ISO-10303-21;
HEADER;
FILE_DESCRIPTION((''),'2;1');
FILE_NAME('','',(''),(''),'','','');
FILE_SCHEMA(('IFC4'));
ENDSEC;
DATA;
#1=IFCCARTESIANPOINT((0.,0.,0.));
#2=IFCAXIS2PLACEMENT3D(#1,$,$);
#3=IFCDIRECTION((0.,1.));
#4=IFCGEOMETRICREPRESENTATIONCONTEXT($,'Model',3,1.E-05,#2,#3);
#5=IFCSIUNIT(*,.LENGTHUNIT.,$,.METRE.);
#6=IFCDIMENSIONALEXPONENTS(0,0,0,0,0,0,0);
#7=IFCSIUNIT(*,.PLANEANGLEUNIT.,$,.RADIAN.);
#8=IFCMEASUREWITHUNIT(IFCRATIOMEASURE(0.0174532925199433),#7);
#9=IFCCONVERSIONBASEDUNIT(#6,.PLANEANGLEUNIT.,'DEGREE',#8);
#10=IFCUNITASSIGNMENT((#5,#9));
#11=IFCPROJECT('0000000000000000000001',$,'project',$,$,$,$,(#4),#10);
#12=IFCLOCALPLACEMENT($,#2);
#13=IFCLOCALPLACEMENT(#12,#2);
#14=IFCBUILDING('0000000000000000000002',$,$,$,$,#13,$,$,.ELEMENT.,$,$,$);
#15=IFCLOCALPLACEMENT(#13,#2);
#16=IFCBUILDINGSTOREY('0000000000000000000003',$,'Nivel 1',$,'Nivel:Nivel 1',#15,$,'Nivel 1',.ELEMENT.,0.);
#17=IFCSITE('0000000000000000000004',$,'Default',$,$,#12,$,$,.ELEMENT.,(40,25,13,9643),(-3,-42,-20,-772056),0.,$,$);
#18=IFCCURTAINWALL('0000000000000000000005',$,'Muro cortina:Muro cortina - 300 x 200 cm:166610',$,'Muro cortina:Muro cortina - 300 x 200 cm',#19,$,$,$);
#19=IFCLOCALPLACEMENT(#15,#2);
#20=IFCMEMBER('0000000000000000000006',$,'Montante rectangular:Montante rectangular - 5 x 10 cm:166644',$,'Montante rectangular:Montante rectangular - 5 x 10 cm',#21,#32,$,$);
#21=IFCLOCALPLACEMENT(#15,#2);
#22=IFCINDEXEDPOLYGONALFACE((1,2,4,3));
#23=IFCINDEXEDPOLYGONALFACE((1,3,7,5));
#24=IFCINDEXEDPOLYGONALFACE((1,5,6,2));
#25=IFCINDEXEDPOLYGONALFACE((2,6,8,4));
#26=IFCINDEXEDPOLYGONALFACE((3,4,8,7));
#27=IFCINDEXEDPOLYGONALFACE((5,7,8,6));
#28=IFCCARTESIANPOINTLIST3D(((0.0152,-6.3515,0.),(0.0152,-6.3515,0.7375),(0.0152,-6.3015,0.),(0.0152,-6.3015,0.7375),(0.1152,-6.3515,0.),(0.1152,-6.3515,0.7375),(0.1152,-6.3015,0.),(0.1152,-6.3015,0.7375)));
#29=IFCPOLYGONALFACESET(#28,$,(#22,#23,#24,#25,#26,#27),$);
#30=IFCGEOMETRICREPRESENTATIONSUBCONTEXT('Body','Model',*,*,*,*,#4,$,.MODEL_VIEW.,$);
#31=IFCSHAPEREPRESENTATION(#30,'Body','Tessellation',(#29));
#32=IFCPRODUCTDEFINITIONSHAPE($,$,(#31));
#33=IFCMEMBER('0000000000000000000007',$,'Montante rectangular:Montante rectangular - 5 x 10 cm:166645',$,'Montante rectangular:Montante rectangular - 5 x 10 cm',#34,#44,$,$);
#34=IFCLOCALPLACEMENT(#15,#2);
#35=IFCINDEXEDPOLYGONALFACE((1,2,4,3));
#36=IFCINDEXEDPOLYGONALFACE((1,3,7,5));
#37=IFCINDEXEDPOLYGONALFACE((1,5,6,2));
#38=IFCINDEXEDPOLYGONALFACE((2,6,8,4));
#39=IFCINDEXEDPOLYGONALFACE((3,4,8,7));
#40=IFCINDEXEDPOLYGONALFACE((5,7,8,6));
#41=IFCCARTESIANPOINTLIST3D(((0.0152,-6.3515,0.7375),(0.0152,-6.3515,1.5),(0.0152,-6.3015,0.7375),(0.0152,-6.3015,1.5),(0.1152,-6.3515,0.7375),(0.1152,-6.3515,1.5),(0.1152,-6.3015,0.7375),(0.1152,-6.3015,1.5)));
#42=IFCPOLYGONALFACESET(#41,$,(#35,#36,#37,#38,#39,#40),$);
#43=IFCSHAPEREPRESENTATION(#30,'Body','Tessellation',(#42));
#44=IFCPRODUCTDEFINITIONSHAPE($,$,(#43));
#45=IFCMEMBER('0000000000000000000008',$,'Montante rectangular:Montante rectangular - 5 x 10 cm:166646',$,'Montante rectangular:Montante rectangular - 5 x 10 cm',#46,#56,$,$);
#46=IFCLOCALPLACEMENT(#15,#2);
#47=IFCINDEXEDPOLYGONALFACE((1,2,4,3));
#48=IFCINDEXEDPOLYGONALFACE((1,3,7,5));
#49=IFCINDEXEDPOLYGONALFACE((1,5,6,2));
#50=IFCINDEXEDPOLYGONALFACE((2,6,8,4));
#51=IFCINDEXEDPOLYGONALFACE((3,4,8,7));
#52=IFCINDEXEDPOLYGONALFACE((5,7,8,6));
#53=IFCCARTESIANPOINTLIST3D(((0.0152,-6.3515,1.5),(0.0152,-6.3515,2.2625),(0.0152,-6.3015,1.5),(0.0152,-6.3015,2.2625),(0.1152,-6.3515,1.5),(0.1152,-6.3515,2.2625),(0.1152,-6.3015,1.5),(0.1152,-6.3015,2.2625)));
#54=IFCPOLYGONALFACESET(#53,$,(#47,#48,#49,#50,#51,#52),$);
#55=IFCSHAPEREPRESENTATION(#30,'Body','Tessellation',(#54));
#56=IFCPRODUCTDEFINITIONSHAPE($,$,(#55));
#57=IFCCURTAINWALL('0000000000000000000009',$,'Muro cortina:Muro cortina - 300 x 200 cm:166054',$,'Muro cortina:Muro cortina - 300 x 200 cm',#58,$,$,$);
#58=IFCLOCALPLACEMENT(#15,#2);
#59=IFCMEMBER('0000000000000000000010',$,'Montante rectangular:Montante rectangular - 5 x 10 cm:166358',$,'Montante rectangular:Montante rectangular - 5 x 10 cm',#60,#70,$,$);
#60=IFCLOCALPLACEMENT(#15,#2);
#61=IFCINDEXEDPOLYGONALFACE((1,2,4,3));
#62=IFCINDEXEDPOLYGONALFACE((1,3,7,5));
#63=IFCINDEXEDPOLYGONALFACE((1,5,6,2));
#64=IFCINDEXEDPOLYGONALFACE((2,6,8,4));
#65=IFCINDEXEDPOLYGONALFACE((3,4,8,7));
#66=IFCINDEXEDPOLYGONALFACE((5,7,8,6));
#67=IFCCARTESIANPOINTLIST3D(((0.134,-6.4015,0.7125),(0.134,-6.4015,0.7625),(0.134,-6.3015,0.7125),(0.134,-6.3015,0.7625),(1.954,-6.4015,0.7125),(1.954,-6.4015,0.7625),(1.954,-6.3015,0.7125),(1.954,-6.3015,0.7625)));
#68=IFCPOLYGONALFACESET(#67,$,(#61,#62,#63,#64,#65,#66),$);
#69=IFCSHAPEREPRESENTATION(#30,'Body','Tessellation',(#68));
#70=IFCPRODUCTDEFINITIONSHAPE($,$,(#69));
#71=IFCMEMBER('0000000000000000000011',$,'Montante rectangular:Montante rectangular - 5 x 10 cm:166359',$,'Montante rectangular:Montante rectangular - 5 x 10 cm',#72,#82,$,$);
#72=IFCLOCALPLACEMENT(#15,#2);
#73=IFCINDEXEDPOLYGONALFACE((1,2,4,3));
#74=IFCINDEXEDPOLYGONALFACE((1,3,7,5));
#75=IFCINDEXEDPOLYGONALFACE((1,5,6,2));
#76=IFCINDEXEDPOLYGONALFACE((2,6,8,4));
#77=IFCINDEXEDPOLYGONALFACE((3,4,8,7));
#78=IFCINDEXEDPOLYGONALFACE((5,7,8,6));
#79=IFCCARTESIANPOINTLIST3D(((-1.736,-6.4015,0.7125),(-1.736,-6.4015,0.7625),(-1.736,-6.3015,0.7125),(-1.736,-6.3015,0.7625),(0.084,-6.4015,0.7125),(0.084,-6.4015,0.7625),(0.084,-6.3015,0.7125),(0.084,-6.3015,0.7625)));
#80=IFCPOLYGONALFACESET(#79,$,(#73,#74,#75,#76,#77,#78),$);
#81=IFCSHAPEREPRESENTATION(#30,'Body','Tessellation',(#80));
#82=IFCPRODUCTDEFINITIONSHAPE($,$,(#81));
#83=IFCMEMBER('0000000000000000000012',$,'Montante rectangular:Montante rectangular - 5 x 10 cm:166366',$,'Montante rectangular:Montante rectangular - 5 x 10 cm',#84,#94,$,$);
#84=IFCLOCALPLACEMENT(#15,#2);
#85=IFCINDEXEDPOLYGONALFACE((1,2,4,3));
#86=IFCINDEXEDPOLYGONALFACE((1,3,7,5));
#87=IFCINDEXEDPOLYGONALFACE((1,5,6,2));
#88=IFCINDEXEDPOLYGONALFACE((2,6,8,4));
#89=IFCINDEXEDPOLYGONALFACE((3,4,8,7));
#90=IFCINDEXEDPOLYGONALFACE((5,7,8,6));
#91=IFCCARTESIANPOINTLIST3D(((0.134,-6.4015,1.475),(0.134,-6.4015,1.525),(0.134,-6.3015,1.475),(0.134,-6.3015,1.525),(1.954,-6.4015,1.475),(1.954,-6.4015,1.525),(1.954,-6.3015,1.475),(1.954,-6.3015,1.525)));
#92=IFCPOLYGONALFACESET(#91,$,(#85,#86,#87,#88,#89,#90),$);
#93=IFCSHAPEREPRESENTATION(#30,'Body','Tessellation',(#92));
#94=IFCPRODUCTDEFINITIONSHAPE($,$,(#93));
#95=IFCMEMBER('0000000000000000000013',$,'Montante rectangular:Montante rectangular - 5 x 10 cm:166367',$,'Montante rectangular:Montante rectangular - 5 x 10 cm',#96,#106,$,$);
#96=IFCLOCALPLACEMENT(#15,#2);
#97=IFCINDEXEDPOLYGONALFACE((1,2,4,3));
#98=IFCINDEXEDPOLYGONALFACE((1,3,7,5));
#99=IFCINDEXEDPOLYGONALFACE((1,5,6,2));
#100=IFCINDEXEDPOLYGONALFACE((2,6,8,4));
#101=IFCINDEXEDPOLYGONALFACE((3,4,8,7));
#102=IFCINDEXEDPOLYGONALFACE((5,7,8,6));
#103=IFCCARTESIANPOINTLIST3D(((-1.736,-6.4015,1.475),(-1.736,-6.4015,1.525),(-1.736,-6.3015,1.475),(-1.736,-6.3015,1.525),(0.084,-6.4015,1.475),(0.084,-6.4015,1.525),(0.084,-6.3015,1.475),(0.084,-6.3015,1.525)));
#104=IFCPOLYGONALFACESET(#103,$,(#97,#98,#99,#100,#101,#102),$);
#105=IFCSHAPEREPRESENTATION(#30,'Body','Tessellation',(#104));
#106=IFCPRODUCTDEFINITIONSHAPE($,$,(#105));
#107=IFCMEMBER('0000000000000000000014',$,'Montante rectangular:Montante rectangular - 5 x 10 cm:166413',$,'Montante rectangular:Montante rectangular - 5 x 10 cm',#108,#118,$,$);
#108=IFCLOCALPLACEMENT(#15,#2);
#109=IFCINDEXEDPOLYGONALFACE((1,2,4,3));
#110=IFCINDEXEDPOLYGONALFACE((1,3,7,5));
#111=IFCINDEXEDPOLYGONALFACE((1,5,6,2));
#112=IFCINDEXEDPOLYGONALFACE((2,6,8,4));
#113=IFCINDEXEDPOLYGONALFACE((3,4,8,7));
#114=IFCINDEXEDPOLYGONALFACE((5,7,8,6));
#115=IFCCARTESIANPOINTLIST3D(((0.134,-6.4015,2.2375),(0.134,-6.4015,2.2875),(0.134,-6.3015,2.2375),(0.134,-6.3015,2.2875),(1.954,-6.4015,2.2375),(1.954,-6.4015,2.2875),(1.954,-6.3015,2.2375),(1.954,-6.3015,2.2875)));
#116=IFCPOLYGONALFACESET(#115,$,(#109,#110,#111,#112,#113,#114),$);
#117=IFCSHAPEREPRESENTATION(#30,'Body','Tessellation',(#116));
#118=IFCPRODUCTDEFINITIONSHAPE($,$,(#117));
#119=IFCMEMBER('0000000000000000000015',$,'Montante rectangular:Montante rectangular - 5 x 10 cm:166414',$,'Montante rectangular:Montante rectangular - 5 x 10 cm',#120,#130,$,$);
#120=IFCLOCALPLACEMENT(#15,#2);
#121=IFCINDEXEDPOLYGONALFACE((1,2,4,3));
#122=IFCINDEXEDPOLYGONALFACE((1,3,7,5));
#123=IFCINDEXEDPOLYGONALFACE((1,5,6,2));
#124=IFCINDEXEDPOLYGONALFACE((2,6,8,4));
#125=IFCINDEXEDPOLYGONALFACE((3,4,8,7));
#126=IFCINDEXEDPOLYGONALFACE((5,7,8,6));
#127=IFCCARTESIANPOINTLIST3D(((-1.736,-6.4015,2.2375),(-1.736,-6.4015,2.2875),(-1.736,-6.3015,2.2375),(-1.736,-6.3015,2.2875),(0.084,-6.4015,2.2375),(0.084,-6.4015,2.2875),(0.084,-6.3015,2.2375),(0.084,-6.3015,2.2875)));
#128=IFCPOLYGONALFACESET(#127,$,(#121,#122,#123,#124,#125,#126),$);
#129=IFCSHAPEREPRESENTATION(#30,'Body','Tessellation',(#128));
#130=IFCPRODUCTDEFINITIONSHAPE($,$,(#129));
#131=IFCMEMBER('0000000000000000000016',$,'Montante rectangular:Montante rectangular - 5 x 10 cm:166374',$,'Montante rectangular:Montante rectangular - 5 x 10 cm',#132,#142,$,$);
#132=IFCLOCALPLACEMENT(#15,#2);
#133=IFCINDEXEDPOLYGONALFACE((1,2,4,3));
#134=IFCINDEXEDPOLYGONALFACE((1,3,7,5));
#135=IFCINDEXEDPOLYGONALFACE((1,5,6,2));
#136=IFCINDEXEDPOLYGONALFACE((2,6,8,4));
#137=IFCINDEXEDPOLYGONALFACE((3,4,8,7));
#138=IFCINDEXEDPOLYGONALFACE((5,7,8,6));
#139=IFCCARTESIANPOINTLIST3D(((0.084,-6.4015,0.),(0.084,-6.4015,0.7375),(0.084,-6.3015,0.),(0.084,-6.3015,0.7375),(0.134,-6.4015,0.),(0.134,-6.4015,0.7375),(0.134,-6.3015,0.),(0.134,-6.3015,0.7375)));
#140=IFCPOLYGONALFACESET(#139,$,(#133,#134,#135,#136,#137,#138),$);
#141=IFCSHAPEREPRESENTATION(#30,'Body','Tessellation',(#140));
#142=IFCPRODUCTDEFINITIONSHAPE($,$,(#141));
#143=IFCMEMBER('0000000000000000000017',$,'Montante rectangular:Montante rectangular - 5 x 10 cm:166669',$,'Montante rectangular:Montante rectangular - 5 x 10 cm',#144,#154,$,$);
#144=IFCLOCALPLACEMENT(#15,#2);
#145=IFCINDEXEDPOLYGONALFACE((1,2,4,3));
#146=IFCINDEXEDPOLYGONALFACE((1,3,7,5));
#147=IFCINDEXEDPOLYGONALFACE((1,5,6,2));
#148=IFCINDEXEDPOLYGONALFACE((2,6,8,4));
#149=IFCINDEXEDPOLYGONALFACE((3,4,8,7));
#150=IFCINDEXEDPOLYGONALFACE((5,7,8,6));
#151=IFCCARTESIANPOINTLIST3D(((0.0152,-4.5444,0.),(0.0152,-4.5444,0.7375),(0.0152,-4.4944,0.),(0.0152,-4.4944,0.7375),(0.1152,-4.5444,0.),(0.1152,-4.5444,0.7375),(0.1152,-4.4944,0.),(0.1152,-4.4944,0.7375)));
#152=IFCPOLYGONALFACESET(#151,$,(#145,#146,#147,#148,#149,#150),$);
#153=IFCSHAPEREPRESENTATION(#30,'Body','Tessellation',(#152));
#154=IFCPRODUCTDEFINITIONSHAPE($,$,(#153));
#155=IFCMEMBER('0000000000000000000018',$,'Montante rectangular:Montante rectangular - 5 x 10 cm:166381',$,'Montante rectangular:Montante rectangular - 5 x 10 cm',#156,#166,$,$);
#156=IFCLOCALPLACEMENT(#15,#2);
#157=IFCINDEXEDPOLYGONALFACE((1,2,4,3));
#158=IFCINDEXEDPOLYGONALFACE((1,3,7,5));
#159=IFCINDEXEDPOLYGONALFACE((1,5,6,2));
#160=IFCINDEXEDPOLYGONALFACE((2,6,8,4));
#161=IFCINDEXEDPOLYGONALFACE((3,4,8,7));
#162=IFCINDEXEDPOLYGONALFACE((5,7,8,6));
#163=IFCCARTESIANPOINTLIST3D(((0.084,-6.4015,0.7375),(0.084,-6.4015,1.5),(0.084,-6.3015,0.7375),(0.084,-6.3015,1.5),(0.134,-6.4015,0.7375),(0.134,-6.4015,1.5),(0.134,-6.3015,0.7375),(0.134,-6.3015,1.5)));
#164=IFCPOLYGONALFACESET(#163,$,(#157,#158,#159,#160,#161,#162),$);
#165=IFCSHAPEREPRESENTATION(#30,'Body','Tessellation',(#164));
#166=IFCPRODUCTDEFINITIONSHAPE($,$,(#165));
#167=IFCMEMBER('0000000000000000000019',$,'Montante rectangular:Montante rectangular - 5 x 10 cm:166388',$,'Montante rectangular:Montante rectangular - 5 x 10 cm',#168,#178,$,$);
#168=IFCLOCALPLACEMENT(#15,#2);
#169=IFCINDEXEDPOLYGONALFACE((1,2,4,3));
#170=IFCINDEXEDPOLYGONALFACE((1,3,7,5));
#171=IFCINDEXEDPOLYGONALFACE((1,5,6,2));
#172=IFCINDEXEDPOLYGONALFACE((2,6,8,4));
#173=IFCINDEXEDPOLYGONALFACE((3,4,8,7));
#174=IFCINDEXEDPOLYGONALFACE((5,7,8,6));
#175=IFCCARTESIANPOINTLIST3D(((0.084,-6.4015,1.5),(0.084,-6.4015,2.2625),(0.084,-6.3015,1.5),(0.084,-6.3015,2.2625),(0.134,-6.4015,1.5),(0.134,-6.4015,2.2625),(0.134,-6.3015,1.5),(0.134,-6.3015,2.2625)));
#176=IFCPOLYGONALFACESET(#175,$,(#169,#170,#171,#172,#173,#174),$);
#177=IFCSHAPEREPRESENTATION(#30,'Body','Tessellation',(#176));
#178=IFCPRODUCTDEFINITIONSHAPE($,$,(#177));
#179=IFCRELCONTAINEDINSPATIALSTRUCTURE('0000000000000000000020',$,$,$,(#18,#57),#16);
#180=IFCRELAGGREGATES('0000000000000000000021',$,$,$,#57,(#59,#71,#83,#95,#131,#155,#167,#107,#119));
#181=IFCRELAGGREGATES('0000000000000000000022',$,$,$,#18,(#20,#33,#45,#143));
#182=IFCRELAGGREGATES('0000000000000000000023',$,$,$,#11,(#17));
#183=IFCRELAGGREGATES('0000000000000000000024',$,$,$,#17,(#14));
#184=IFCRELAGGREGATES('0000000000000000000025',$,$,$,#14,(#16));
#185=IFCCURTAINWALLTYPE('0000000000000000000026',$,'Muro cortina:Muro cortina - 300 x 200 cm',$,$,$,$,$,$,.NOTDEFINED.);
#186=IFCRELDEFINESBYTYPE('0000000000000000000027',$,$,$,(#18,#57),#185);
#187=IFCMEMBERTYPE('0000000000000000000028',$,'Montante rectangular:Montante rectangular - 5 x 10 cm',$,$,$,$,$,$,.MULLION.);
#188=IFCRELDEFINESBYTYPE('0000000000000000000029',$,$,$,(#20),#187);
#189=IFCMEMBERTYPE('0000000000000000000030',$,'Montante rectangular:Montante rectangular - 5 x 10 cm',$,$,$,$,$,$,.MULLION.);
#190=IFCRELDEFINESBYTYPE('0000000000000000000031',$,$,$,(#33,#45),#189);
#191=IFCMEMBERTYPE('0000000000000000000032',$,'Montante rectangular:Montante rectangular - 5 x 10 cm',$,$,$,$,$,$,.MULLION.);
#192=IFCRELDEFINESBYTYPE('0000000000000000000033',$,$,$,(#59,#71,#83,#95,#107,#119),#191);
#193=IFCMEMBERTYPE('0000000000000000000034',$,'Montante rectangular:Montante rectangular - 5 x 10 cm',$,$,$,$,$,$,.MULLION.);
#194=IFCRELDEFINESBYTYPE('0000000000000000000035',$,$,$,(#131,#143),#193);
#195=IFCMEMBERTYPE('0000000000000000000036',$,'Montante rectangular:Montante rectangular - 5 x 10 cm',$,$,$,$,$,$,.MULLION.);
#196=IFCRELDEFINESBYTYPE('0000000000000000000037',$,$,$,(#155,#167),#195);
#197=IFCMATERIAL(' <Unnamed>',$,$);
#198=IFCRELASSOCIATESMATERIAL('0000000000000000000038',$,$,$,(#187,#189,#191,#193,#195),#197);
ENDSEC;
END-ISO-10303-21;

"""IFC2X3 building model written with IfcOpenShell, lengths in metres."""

from ifc_helpers import new_model, entity, si_unit, converted_unit, direction, frame, origin, origin_2d_with_axis, place, context, subcontext, project, spatial, rectangle, extrude, source, transform, mapped, material, type_object, type_shapes, element, aggregate, save


model = new_model("IFC2X3")

# Units and contexts
model_context = context("Model", 3, precision=1e-05, world=origin(), true_north=direction((0.0, 1.0)))
body_context = subcontext(model_context, "Body", "Model", "MODEL_VIEW")
ifc_project = project(units=[si_unit("LENGTHUNIT", "METRE"), converted_unit("PLANEANGLEUNIT", "DEGREE", entity("IfcRatioMeasure", 0.0174532925199433), si_unit("PLANEANGLEUNIT", "RADIAN"), dimensions=[0, 0, 0, 0, 0, 0, 0])], contexts=[model_context])

# Site, building, storey
site_placement = place(None, origin())
site = spatial("IfcSite", under=ifc_project, at=site_placement, Name="Default", CompositionType="ELEMENT", RefLatitude=(40, 25, 13, 9643), RefLongitude=(-3, -42, -20, -772056), RefElevation=0.0)
building_placement = place(site_placement, origin())
building = spatial("IfcBuilding", under=site, at=building_placement, CompositionType="ELEMENT")
storey_placement = place(building_placement, origin())
storey = spatial("IfcBuildingStorey", under=building, at=storey_placement, Name="Nivel 1", ObjectType="Nivel:Nivel 1", LongName="Nivel 1", CompositionType="ELEMENT", Elevation=0.0)

# Curtain walls, members
curtain_wall_type = type_object("IfcCurtainWallType", Name="Muro cortina:Muro cortina - 300 x 200 cm", PredefinedType="NOTDEFINED")
curtain_wall_1_placement = place(storey_placement, origin())
curtain_wall_1 = element("IfcCurtainWall", 1, at=curtain_wall_1_placement, inside=storey, type_object=curtain_wall_type, Name="Muro cortina:Muro cortina - 300 x 200 cm:166610", ObjectType="Muro cortina:Muro cortina - 300 x 200 cm")
ifc_material_1 = material(Name=" <Unnamed>")
member_type_1 = type_object("IfcMemberType", Name="Montante rectangular:Montante rectangular - 5 x 10 cm", PredefinedType="MULLION", material=ifc_material_1)
shared_shape_1 = source(origin(), body_context, "Body", "SweptSolid", [
    extrude(rectangle(XDim=0.1, YDim=0.05, at=origin_2d_with_axis()), frame((-0.025, 0.0, -0.7375), z_axis=(0.0, 0.0, 1.0), x_axis=(0.0, -1.0, 0.0)), (0.0, 0.0, 1.0), 0.7375),
])
type_shapes(member_type_1, [shared_shape_1])
member_1_placement = place(storey_placement, frame((0.0652, -6.3515, 0.0), z_axis=(0.0, 0.0, -1.0), x_axis=(0.0, -1.0, 0.0)))
member_1 = element("IfcMember", 2, at=member_1_placement, type_object=member_type_1, Name="Montante rectangular:Montante rectangular - 5 x 10 cm:166644", ObjectType="Montante rectangular:Montante rectangular - 5 x 10 cm", context=body_context, shape_type="MappedRepresentation", body=[
    mapped(shared_shape_1, transform((0.0, 0.0, 0.0), scale=1.0)),
])
member_type_2 = type_object("IfcMemberType", Name="Montante rectangular:Montante rectangular - 5 x 10 cm", PredefinedType="MULLION", material=ifc_material_1)
shared_shape_2 = source(origin(), body_context, "Body", "SweptSolid", [
    extrude(rectangle(XDim=0.1, YDim=0.05, at=origin_2d_with_axis()), frame((-0.025, 0.0, -0.7625), z_axis=(0.0, 0.0, 1.0), x_axis=(0.0, -1.0, 0.0)), (0.0, 0.0, 1.0), 0.7625),
])
type_shapes(member_type_2, [shared_shape_2])
member_2_placement = place(storey_placement, frame((0.0652, -6.3515, 0.7375), z_axis=(0.0, 0.0, -1.0), x_axis=(0.0, -1.0, 0.0)))
member_2 = element("IfcMember", 3, at=member_2_placement, type_object=member_type_2, Name="Montante rectangular:Montante rectangular - 5 x 10 cm:166645", ObjectType="Montante rectangular:Montante rectangular - 5 x 10 cm", context=body_context, shape_type="MappedRepresentation", body=[
    mapped(shared_shape_2, transform((0.0, 0.0, 0.0), scale=1.0)),
])
member_3_placement = place(storey_placement, frame((0.0652, -6.3515, 1.5), z_axis=(0.0, 0.0, -1.0), x_axis=(0.0, -1.0, 0.0)))
member_3 = element("IfcMember", 4, at=member_3_placement, type_object=member_type_2, Name="Montante rectangular:Montante rectangular - 5 x 10 cm:166646", ObjectType="Montante rectangular:Montante rectangular - 5 x 10 cm", context=body_context, shape_type="MappedRepresentation", body=[
    mapped(shared_shape_2, transform((0.0, 0.0, 0.0), scale=1.0)),
])
curtain_wall_2_placement = place(storey_placement, origin())
curtain_wall_2 = element("IfcCurtainWall", 5, at=curtain_wall_2_placement, inside=storey, type_object=curtain_wall_type, Name="Muro cortina:Muro cortina - 300 x 200 cm:166054", ObjectType="Muro cortina:Muro cortina - 300 x 200 cm")
member_type_3 = type_object("IfcMemberType", Name="Montante rectangular:Montante rectangular - 5 x 10 cm", PredefinedType="MULLION", material=ifc_material_1)
shared_shape_3 = source(origin(), body_context, "Body", "SweptSolid", [
    extrude(rectangle(XDim=0.1, YDim=0.05, at=origin_2d_with_axis()), frame((0.0, 0.0, -1.82), z_axis=(0.0, 0.0, 1.0), x_axis=(0.0, -1.0, 0.0)), (0.0, 0.0, 1.0), 1.82),
])
type_shapes(member_type_3, [shared_shape_3])
member_4_placement = place(storey_placement, frame((0.134, -6.3515, 0.7375), z_axis=(-1.0, 0.0, 0.0), x_axis=(0.0, 0.0, 1.0)))
member_4 = element("IfcMember", 6, at=member_4_placement, type_object=member_type_3, Name="Montante rectangular:Montante rectangular - 5 x 10 cm:166358", ObjectType="Montante rectangular:Montante rectangular - 5 x 10 cm", context=body_context, shape_type="MappedRepresentation", body=[
    mapped(shared_shape_3, transform((0.0, 0.0, 0.0), scale=1.0)),
])
member_5_placement = place(storey_placement, frame((-1.736, -6.3515, 0.7375), z_axis=(-1.0, 0.0, 0.0), x_axis=(0.0, 0.0, 1.0)))
member_5 = element("IfcMember", 7, at=member_5_placement, type_object=member_type_3, Name="Montante rectangular:Montante rectangular - 5 x 10 cm:166359", ObjectType="Montante rectangular:Montante rectangular - 5 x 10 cm", context=body_context, shape_type="MappedRepresentation", body=[
    mapped(shared_shape_3, transform((0.0, 0.0, 0.0), scale=1.0)),
])
member_6_placement = place(storey_placement, frame((0.134, -6.3515, 1.5), z_axis=(-1.0, 0.0, 0.0), x_axis=(0.0, 0.0, 1.0)))
member_6 = element("IfcMember", 8, at=member_6_placement, type_object=member_type_3, Name="Montante rectangular:Montante rectangular - 5 x 10 cm:166366", ObjectType="Montante rectangular:Montante rectangular - 5 x 10 cm", context=body_context, shape_type="MappedRepresentation", body=[
    mapped(shared_shape_3, transform((0.0, 0.0, 0.0), scale=1.0)),
])
member_7_placement = place(storey_placement, frame((-1.736, -6.3515, 1.5), z_axis=(-1.0, 0.0, 0.0), x_axis=(0.0, 0.0, 1.0)))
member_7 = element("IfcMember", 9, at=member_7_placement, type_object=member_type_3, Name="Montante rectangular:Montante rectangular - 5 x 10 cm:166367", ObjectType="Montante rectangular:Montante rectangular - 5 x 10 cm", context=body_context, shape_type="MappedRepresentation", body=[
    mapped(shared_shape_3, transform((0.0, 0.0, 0.0), scale=1.0)),
])
member_8_placement = place(storey_placement, frame((0.134, -6.3515, 2.2625), z_axis=(-1.0, 0.0, 0.0), x_axis=(0.0, 0.0, 1.0)))
member_8 = element("IfcMember", 10, at=member_8_placement, type_object=member_type_3, Name="Montante rectangular:Montante rectangular - 5 x 10 cm:166413", ObjectType="Montante rectangular:Montante rectangular - 5 x 10 cm", context=body_context, shape_type="MappedRepresentation", body=[
    mapped(shared_shape_3, transform((0.0, 0.0, 0.0), scale=1.0)),
])
member_9_placement = place(storey_placement, frame((-1.736, -6.3515, 2.2625), z_axis=(-1.0, 0.0, 0.0), x_axis=(0.0, 0.0, 1.0)))
member_9 = element("IfcMember", 11, at=member_9_placement, type_object=member_type_3, Name="Montante rectangular:Montante rectangular - 5 x 10 cm:166414", ObjectType="Montante rectangular:Montante rectangular - 5 x 10 cm", context=body_context, shape_type="MappedRepresentation", body=[
    mapped(shared_shape_3, transform((0.0, 0.0, 0.0), scale=1.0)),
])
member_type_4 = type_object("IfcMemberType", Name="Montante rectangular:Montante rectangular - 5 x 10 cm", PredefinedType="MULLION", material=ifc_material_1)
shared_shape_4 = source(origin(), body_context, "Body", "SweptSolid", [
    extrude(rectangle(XDim=0.1, YDim=0.05, at=origin_2d_with_axis()), frame((0.0, 0.0, -0.7375), z_axis=(0.0, 0.0, 1.0), x_axis=(0.0, -1.0, 0.0)), (0.0, 0.0, 1.0), 0.7375),
])
type_shapes(member_type_4, [shared_shape_4])
member_10_placement = place(storey_placement, frame((0.109, -6.3515, 0.0), z_axis=(0.0, 0.0, -1.0), x_axis=(-1.0, 0.0, 0.0)))
member_10 = element("IfcMember", 12, at=member_10_placement, type_object=member_type_4, Name="Montante rectangular:Montante rectangular - 5 x 10 cm:166374", ObjectType="Montante rectangular:Montante rectangular - 5 x 10 cm", context=body_context, shape_type="MappedRepresentation", body=[
    mapped(shared_shape_4, transform((0.0, 0.0, 0.0), scale=1.0)),
])

# Members
member_11_placement = place(storey_placement, frame((0.0652, -4.5194, 0.0), z_axis=(0.0, 0.0, -1.0), x_axis=(0.0, -1.0, 0.0)))
member_11 = element("IfcMember", 13, at=member_11_placement, type_object=member_type_4, Name="Montante rectangular:Montante rectangular - 5 x 10 cm:166669", ObjectType="Montante rectangular:Montante rectangular - 5 x 10 cm", context=body_context, shape_type="MappedRepresentation", body=[
    mapped(shared_shape_4, transform((0.0, 0.0, 0.0), scale=1.0)),
])
member_type_5 = type_object("IfcMemberType", Name="Montante rectangular:Montante rectangular - 5 x 10 cm", PredefinedType="MULLION", material=ifc_material_1)
shared_shape_5 = source(origin(), body_context, "Body", "SweptSolid", [
    extrude(rectangle(XDim=0.1, YDim=0.05, at=origin_2d_with_axis()), frame((0.0, 0.0, -0.7625), z_axis=(0.0, 0.0, 1.0), x_axis=(0.0, -1.0, 0.0)), (0.0, 0.0, 1.0), 0.7625),
])
type_shapes(member_type_5, [shared_shape_5])
member_12_placement = place(storey_placement, frame((0.109, -6.3515, 0.7375), z_axis=(0.0, 0.0, -1.0), x_axis=(-1.0, 0.0, 0.0)))
member_12 = element("IfcMember", 14, at=member_12_placement, type_object=member_type_5, Name="Montante rectangular:Montante rectangular - 5 x 10 cm:166381", ObjectType="Montante rectangular:Montante rectangular - 5 x 10 cm", context=body_context, shape_type="MappedRepresentation", body=[
    mapped(shared_shape_5, transform((0.0, 0.0, 0.0), scale=1.0)),
])
member_13_placement = place(storey_placement, frame((0.109, -6.3515, 1.5), z_axis=(0.0, 0.0, -1.0), x_axis=(-1.0, 0.0, 0.0)))
member_13 = element("IfcMember", 15, at=member_13_placement, type_object=member_type_5, Name="Montante rectangular:Montante rectangular - 5 x 10 cm:166388", ObjectType="Montante rectangular:Montante rectangular - 5 x 10 cm", context=body_context, shape_type="MappedRepresentation", body=[
    mapped(shared_shape_5, transform((0.0, 0.0, 0.0), scale=1.0)),
])

aggregate(curtain_wall_2, [member_4, member_5, member_6, member_7, member_10, member_12, member_13, member_8, member_9])
aggregate(curtain_wall_1, [member_1, member_2, member_3, member_11])

save(model, "model.ifc")
